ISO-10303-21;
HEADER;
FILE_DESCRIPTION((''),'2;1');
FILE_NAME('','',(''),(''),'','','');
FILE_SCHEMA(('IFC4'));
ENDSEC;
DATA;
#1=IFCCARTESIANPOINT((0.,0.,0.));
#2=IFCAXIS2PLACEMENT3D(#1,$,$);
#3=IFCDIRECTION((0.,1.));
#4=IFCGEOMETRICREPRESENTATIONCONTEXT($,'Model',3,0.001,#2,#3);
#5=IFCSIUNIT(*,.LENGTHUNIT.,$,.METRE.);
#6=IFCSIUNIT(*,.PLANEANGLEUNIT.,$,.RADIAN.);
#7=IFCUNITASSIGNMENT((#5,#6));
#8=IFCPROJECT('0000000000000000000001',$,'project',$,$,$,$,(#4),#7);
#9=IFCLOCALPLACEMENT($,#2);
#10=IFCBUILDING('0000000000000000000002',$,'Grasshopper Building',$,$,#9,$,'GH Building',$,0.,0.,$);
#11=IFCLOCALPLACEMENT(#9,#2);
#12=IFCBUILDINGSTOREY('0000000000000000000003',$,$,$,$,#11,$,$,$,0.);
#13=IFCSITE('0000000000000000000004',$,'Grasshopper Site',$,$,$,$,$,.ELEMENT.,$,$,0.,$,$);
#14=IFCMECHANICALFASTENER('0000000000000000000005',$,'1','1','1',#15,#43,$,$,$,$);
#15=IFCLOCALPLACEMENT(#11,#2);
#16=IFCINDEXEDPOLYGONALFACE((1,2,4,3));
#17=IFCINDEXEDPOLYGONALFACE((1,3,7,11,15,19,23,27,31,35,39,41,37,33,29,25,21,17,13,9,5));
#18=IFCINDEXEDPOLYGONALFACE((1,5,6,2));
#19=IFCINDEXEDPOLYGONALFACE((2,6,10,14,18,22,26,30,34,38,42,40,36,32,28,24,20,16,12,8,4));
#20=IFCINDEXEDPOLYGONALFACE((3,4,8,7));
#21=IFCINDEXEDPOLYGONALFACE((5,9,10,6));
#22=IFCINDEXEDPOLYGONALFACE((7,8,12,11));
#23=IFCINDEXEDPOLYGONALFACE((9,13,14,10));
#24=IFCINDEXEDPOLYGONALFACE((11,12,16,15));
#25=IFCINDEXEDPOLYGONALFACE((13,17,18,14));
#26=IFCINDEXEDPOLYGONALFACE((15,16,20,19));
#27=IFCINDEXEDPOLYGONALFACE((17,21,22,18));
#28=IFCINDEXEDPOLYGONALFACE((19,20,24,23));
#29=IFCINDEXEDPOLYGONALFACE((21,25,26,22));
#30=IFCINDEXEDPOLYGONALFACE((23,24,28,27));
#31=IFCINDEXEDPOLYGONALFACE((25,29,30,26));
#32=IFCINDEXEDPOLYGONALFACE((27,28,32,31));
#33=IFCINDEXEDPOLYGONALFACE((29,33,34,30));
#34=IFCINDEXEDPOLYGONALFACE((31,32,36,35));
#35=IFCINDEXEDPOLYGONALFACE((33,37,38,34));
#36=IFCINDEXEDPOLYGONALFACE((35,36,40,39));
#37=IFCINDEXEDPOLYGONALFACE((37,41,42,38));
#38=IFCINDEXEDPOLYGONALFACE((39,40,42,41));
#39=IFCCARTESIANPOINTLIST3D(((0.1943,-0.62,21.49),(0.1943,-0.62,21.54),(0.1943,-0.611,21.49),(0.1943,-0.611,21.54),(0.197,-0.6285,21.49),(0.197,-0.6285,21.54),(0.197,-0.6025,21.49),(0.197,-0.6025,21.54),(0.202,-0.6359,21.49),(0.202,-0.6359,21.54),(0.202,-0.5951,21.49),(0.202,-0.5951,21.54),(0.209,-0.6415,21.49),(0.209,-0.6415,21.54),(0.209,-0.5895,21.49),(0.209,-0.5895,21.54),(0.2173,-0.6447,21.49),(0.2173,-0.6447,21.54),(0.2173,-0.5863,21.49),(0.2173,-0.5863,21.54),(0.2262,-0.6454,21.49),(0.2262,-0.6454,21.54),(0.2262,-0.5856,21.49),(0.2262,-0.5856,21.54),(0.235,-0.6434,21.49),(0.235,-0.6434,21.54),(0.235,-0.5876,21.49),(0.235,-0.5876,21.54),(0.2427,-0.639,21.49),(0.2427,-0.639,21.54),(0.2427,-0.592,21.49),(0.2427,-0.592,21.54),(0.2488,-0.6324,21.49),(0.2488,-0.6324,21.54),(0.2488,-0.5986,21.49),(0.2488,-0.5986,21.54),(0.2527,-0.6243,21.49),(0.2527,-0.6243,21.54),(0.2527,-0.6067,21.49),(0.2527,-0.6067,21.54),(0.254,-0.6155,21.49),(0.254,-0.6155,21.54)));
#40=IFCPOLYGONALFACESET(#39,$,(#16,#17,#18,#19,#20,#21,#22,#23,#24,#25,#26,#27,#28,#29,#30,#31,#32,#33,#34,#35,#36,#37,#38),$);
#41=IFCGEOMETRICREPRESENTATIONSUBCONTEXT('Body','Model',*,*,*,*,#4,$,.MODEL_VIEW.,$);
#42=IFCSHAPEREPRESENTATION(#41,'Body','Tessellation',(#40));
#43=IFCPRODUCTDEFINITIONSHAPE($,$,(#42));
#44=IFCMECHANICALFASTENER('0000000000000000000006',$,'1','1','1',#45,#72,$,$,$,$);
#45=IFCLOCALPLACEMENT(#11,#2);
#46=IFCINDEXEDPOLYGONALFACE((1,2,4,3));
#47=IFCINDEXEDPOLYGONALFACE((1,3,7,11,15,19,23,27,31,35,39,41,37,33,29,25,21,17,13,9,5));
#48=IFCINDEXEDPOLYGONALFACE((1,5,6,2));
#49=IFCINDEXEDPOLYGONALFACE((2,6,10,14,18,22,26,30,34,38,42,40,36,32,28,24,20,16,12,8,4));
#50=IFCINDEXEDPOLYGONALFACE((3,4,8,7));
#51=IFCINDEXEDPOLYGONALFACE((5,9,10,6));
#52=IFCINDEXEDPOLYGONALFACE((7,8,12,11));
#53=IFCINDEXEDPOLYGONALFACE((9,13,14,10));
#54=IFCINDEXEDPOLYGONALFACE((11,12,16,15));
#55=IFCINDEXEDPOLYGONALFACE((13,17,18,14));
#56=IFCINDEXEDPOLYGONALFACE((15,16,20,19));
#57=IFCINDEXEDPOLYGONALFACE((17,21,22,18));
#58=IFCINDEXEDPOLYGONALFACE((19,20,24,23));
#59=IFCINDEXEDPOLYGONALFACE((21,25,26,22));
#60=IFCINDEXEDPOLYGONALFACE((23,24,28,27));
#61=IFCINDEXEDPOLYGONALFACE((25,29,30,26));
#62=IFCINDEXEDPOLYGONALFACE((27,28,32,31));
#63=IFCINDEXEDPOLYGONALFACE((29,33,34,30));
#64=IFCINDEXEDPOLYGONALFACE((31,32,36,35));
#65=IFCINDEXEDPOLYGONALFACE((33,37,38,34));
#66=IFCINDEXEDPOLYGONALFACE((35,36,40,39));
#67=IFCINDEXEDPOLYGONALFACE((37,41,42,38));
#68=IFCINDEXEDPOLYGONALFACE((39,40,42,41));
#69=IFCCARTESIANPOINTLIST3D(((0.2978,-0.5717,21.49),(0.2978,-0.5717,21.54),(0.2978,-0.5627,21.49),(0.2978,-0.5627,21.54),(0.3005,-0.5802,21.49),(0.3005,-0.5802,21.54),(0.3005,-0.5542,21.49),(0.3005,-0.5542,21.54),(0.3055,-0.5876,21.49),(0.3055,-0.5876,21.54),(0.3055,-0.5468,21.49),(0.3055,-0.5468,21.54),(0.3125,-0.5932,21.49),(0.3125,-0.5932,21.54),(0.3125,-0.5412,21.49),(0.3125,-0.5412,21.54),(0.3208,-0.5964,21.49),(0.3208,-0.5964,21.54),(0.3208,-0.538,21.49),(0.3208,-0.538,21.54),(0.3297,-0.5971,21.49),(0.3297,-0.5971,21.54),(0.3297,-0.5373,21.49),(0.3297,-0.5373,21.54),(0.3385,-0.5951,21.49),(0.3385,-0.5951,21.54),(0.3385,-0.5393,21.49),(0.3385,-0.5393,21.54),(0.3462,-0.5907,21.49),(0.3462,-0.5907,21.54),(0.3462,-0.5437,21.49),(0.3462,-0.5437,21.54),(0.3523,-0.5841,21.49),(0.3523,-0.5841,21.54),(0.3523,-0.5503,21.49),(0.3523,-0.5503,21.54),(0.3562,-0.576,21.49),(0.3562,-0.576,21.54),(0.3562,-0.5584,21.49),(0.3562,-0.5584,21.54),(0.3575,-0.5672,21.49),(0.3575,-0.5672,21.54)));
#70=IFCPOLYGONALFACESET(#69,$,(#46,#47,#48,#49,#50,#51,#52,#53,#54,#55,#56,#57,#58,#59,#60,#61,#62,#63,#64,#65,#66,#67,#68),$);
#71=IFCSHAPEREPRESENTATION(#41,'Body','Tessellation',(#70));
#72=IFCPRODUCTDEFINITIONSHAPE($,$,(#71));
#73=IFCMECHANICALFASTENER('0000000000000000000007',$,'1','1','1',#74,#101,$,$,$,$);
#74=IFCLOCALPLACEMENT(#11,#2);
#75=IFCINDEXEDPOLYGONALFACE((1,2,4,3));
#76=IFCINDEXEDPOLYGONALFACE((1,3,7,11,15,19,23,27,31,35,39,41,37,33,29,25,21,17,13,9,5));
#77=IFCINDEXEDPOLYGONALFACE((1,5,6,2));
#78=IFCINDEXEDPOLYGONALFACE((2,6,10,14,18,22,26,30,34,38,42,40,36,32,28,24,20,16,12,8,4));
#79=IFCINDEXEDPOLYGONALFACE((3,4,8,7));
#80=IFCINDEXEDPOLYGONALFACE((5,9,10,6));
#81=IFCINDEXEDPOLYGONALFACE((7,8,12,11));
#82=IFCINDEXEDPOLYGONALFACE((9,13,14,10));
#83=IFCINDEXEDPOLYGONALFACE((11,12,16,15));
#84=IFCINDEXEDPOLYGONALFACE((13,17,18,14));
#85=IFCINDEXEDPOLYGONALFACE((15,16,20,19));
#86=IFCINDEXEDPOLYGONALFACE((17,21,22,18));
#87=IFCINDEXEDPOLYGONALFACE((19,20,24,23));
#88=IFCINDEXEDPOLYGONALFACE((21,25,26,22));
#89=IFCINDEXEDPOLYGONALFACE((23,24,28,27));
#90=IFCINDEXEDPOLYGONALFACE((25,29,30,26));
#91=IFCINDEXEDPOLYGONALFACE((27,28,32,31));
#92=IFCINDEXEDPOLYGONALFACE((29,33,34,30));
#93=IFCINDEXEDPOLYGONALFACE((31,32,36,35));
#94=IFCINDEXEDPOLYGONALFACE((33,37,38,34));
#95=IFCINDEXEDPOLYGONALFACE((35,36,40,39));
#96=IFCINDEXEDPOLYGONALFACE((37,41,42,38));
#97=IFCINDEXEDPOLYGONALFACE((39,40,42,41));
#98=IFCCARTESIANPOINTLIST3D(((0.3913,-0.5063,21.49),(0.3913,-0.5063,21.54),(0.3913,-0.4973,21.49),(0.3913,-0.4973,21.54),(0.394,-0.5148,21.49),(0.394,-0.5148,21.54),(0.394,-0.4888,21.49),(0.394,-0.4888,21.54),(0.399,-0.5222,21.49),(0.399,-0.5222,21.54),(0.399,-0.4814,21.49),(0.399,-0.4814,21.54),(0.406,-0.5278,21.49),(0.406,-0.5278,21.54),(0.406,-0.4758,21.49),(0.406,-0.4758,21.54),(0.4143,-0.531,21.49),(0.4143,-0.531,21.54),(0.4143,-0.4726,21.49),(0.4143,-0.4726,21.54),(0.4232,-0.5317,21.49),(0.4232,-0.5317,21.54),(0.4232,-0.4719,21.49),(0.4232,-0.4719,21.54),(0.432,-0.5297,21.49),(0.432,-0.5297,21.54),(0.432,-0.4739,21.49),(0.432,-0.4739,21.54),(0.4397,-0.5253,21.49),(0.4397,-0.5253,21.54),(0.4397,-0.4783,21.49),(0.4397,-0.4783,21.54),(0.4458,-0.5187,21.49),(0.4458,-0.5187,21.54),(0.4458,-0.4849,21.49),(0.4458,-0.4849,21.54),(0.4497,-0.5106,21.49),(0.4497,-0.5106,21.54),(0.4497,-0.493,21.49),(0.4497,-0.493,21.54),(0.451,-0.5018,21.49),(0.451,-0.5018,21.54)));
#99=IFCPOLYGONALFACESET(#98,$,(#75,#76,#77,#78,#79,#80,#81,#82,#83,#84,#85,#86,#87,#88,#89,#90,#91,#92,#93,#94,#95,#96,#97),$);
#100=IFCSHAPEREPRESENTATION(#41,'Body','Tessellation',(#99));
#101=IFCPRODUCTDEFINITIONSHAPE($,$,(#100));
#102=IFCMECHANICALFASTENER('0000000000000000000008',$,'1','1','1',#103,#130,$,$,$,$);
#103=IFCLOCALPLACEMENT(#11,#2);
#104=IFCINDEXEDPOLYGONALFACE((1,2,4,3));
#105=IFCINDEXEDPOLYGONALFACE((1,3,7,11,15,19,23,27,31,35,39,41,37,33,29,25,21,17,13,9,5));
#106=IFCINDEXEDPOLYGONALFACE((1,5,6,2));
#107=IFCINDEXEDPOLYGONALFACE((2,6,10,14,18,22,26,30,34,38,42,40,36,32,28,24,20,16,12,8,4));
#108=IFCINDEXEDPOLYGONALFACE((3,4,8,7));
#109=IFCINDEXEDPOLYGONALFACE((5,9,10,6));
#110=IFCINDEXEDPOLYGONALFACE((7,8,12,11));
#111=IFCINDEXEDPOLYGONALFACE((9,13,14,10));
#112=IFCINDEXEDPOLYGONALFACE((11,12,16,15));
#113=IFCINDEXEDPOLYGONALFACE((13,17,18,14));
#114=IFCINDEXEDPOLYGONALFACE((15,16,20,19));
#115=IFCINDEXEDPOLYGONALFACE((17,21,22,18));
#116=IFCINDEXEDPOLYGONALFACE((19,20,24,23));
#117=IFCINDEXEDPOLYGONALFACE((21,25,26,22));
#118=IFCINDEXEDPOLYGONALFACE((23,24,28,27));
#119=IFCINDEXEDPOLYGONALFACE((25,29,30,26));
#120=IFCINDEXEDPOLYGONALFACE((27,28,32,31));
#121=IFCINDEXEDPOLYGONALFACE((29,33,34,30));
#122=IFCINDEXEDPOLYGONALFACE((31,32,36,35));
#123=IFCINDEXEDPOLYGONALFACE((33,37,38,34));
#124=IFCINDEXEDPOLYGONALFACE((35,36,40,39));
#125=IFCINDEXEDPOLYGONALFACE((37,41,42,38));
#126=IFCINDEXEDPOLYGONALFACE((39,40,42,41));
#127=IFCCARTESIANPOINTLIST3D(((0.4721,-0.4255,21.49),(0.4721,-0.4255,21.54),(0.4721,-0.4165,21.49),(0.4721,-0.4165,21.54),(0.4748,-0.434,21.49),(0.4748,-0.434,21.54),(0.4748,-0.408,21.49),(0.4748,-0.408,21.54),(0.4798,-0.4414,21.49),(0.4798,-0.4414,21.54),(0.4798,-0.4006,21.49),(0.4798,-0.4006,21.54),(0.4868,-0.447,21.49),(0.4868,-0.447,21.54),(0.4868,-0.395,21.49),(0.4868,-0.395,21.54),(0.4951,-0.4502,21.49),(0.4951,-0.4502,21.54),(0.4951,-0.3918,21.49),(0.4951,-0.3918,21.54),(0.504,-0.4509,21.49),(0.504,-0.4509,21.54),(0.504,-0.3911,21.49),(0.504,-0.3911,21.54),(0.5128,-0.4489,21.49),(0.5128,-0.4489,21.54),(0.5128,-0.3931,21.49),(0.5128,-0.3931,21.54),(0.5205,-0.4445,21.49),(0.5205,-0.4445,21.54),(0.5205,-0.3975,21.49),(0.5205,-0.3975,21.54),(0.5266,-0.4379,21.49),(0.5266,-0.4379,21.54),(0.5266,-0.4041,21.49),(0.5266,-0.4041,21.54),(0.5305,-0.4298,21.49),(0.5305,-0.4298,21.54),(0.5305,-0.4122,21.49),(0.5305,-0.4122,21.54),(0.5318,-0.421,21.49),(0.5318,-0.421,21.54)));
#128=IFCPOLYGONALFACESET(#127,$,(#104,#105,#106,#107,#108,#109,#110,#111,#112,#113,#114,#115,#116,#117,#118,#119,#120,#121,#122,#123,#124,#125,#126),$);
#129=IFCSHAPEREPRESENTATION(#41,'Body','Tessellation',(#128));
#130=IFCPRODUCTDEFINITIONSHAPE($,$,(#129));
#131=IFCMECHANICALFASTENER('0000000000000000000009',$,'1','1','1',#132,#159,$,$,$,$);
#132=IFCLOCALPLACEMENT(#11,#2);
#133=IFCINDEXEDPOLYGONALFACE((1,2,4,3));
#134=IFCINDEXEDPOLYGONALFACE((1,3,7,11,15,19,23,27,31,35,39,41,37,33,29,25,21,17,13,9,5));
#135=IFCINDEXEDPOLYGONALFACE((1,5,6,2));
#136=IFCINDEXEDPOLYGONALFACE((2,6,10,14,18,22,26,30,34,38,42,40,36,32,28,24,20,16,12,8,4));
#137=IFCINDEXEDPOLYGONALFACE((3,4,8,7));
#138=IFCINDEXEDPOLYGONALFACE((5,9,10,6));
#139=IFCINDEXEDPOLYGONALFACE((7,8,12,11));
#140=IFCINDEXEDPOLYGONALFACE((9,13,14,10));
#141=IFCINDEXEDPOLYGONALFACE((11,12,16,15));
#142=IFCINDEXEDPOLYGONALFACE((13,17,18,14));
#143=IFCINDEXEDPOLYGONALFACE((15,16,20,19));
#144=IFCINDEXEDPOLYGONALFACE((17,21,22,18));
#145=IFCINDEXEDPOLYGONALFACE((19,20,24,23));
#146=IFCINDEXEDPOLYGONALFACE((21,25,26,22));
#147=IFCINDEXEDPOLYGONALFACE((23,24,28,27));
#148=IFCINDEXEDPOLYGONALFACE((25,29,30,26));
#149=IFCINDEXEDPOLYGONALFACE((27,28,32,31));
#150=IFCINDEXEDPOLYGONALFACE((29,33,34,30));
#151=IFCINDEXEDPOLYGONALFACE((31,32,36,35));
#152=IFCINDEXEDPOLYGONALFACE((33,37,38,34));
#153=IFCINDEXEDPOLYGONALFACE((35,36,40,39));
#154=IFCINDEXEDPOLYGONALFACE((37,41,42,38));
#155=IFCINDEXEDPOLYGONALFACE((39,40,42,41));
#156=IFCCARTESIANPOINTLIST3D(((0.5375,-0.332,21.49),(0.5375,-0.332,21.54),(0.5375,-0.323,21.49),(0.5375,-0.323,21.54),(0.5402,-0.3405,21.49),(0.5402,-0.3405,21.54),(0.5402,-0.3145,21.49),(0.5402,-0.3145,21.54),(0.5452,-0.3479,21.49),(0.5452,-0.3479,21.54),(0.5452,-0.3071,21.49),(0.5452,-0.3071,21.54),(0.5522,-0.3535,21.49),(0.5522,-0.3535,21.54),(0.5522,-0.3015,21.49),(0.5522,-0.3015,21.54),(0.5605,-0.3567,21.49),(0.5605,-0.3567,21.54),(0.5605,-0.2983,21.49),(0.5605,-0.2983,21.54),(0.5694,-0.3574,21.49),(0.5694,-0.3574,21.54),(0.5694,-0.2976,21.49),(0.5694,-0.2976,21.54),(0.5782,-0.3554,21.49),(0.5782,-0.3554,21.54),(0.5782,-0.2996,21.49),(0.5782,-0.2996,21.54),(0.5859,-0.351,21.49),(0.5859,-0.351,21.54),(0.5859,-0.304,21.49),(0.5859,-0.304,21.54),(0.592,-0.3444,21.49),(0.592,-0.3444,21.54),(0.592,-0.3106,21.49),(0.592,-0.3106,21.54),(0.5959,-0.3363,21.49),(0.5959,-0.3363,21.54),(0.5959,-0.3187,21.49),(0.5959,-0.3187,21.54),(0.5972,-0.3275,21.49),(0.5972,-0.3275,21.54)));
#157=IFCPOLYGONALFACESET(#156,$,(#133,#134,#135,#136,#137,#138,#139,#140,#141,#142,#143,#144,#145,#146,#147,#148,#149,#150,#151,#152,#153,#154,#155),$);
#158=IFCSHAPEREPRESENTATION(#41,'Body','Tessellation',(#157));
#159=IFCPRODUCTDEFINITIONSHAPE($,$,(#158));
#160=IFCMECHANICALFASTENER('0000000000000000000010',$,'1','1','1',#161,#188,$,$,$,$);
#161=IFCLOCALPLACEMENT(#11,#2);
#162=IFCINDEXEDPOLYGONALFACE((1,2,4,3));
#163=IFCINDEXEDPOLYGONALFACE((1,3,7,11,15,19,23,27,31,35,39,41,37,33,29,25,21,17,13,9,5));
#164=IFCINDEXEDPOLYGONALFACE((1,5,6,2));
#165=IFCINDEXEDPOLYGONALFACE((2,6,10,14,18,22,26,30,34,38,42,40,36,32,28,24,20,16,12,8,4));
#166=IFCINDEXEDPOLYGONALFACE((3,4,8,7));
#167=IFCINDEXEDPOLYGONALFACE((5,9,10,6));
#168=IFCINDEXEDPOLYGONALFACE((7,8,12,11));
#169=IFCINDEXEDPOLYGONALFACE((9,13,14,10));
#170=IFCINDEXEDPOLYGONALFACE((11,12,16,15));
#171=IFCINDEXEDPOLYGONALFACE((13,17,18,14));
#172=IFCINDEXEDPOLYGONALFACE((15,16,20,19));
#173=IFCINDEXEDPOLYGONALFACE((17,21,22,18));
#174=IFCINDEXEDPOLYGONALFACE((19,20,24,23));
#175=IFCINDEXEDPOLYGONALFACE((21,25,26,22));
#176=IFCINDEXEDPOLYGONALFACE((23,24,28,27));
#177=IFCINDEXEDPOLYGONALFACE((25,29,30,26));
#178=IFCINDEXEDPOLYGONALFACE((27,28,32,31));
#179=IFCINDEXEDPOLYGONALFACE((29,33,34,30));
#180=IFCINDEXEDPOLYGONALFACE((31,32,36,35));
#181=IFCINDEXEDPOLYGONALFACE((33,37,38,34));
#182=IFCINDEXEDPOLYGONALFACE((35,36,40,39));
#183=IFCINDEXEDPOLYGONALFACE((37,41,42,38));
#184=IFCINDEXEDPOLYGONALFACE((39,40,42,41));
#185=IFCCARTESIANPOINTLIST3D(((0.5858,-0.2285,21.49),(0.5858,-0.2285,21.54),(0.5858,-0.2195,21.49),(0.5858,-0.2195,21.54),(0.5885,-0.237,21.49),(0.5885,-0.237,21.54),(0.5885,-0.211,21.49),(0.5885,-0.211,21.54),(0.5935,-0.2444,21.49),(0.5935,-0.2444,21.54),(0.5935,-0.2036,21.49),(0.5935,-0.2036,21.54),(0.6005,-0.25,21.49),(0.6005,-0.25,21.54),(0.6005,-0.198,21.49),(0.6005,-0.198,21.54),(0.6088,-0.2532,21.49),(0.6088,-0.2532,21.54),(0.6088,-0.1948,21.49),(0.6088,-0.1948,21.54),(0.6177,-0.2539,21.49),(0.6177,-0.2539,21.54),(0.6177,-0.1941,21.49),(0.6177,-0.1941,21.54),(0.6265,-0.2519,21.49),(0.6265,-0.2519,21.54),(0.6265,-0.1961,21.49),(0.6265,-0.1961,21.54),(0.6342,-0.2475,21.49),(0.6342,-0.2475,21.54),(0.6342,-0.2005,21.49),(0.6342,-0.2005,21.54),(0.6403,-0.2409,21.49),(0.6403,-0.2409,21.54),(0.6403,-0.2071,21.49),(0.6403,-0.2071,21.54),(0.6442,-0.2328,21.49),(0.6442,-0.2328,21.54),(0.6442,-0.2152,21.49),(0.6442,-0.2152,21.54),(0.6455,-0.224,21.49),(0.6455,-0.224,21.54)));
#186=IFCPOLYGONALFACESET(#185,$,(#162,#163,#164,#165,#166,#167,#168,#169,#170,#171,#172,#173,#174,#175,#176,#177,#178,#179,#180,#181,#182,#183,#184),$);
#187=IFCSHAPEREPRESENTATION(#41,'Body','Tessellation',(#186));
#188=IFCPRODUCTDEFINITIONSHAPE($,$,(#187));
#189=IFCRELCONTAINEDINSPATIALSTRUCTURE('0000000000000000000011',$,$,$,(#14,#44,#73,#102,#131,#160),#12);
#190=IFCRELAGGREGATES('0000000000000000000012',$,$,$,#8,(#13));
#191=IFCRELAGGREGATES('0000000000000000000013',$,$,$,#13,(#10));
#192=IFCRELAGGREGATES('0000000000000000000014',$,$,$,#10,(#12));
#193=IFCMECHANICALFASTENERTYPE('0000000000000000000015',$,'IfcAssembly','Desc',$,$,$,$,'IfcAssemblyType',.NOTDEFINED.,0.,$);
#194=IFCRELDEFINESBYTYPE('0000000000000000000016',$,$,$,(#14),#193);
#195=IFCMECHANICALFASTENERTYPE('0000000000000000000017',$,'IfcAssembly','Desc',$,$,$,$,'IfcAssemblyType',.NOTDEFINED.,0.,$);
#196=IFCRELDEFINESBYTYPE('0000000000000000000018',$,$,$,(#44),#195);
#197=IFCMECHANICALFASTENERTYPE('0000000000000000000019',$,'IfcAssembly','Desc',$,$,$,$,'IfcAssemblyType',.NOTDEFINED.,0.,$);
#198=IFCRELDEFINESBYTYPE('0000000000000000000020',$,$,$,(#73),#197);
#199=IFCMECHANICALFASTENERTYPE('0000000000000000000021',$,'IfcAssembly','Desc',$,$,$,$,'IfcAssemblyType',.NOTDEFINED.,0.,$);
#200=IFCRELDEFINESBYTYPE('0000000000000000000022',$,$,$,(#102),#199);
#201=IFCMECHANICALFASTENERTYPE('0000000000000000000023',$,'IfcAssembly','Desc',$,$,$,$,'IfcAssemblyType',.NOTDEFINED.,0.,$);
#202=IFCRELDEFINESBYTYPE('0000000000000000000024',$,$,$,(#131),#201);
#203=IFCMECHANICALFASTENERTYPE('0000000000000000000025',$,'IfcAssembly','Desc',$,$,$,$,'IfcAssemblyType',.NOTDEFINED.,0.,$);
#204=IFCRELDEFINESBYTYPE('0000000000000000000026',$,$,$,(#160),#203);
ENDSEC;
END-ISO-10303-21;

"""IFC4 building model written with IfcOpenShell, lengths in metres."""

from ifc_helpers import new_model, si_unit, direction, frame, origin, place, context, subcontext, project, spatial, circle, extrude, source, transform, mapped, type_object, type_shapes, element, save


model = new_model("IFC4")

# Units and contexts
model_context = context("Model", 3, precision=0.001, world=origin(), true_north=direction((0.0, 1.0)))
body_context = subcontext(model_context, "Body", "Model", "MODEL_VIEW")
ifc_project = project(units=[si_unit("LENGTHUNIT", "METRE"), si_unit("PLANEANGLEUNIT", "RADIAN")], contexts=[model_context])

# Site, building, storey
site = spatial("IfcSite", under=ifc_project, Name="Grasshopper Site", CompositionType="ELEMENT", RefElevation=0.0)
building_placement = place(None, origin())
building = spatial("IfcBuilding", under=site, at=building_placement, Name="Grasshopper Building", LongName="GH Building", ElevationOfRefHeight=0.0, ElevationOfTerrain=0.0)
storey_placement = place(building_placement, origin())
storey = spatial("IfcBuildingStorey", under=building, at=storey_placement, Elevation=0.0)

# Mechanical fasteners
mechanical_fastener_type_1 = type_object("IfcMechanicalFastenerType", Name="IfcAssembly", Description="Desc", ElementType="IfcAssemblyType", NominalDiameter=0.0)
shared_shape_1 = source(origin(), body_context, "Body", "SweptSolid", [
    extrude(circle(Radius=0.03), frame((0.224, -0.6155, 21.54), z_axis=(0.0, 0.0, -1.0), x_axis=(1.0, 0.0, 0.0)), (0.0, 0.0, 1.0), 0.05),
])
type_shapes(mechanical_fastener_type_1, [shared_shape_1])
mechanical_fastener_1_placement = place(storey_placement, origin())
element("IfcMechanicalFastener", 1, at=mechanical_fastener_1_placement, inside=storey, type_object=mechanical_fastener_type_1, Name="1", Description="1", ObjectType="1", context=body_context, shape_type="MappedRepresentation", body=[
    mapped(shared_shape_1, transform((0.0, 0.0, 0.0), scale=1.0)),
])
mechanical_fastener_type_2 = type_object("IfcMechanicalFastenerType", Name="IfcAssembly", Description="Desc", ElementType="IfcAssemblyType", NominalDiameter=0.0)
shared_shape_2 = source(origin(), body_context, "Body", "SweptSolid", [
    extrude(circle(Radius=0.03), frame((0.3275, -0.5672, 21.54), z_axis=(0.0, 0.0, -1.0), x_axis=(1.0, 0.0, 0.0)), (0.0, 0.0, 1.0), 0.05),
])
type_shapes(mechanical_fastener_type_2, [shared_shape_2])
mechanical_fastener_2_placement = place(storey_placement, origin())
element("IfcMechanicalFastener", 2, at=mechanical_fastener_2_placement, inside=storey, type_object=mechanical_fastener_type_2, Name="1", Description="1", ObjectType="1", context=body_context, shape_type="MappedRepresentation", body=[
    mapped(shared_shape_2, transform((0.0, 0.0, 0.0), scale=1.0)),
])
mechanical_fastener_type_3 = type_object("IfcMechanicalFastenerType", Name="IfcAssembly", Description="Desc", ElementType="IfcAssemblyType", NominalDiameter=0.0)
shared_shape_3 = source(origin(), body_context, "Body", "SweptSolid", [
    extrude(circle(Radius=0.03), frame((0.421, -0.5018, 21.54), z_axis=(0.0, 0.0, -1.0), x_axis=(1.0, 0.0, 0.0)), (0.0, 0.0, 1.0), 0.05),
])
type_shapes(mechanical_fastener_type_3, [shared_shape_3])
mechanical_fastener_3_placement = place(storey_placement, origin())
element("IfcMechanicalFastener", 3, at=mechanical_fastener_3_placement, inside=storey, type_object=mechanical_fastener_type_3, Name="1", Description="1", ObjectType="1", context=body_context, shape_type="MappedRepresentation", body=[
    mapped(shared_shape_3, transform((0.0, 0.0, 0.0), scale=1.0)),
])
mechanical_fastener_type_4 = type_object("IfcMechanicalFastenerType", Name="IfcAssembly", Description="Desc", ElementType="IfcAssemblyType", NominalDiameter=0.0)
shared_shape_4 = source(origin(), body_context, "Body", "SweptSolid", [
    extrude(circle(Radius=0.03), frame((0.5018, -0.421, 21.54), z_axis=(0.0, 0.0, -1.0), x_axis=(1.0, 0.0, 0.0)), (0.0, 0.0, 1.0), 0.05),
])
type_shapes(mechanical_fastener_type_4, [shared_shape_4])
mechanical_fastener_4_placement = place(storey_placement, origin())
element("IfcMechanicalFastener", 4, at=mechanical_fastener_4_placement, inside=storey, type_object=mechanical_fastener_type_4, Name="1", Description="1", ObjectType="1", context=body_context, shape_type="MappedRepresentation", body=[
    mapped(shared_shape_4, transform((0.0, 0.0, 0.0), scale=1.0)),
])
mechanical_fastener_type_5 = type_object("IfcMechanicalFastenerType", Name="IfcAssembly", Description="Desc", ElementType="IfcAssemblyType", NominalDiameter=0.0)
shared_shape_5 = source(origin(), body_context, "Body", "SweptSolid", [
    extrude(circle(Radius=0.03), frame((0.5672, -0.3275, 21.54), z_axis=(0.0, 0.0, -1.0), x_axis=(1.0, 0.0, 0.0)), (0.0, 0.0, 1.0), 0.05),
])
type_shapes(mechanical_fastener_type_5, [shared_shape_5])
mechanical_fastener_5_placement = place(storey_placement, origin())
element("IfcMechanicalFastener", 5, at=mechanical_fastener_5_placement, inside=storey, type_object=mechanical_fastener_type_5, Name="1", Description="1", ObjectType="1", context=body_context, shape_type="MappedRepresentation", body=[
    mapped(shared_shape_5, transform((0.0, 0.0, 0.0), scale=1.0)),
])
mechanical_fastener_type_6 = type_object("IfcMechanicalFastenerType", Name="IfcAssembly", Description="Desc", ElementType="IfcAssemblyType", NominalDiameter=0.0)
shared_shape_6 = source(origin(), body_context, "Body", "SweptSolid", [
    extrude(circle(Radius=0.03), frame((0.6155, -0.224, 21.54), z_axis=(0.0, 0.0, -1.0), x_axis=(1.0, 0.0, 0.0)), (0.0, 0.0, 1.0), 0.05),
])
type_shapes(mechanical_fastener_type_6, [shared_shape_6])
mechanical_fastener_6_placement = place(storey_placement, origin())
element("IfcMechanicalFastener", 6, at=mechanical_fastener_6_placement, inside=storey, type_object=mechanical_fastener_type_6, Name="1", Description="1", ObjectType="1", context=body_context, shape_type="MappedRepresentation", body=[
    mapped(shared_shape_6, transform((0.0, 0.0, 0.0), scale=1.0)),
])

save(model, "model.ifc")
